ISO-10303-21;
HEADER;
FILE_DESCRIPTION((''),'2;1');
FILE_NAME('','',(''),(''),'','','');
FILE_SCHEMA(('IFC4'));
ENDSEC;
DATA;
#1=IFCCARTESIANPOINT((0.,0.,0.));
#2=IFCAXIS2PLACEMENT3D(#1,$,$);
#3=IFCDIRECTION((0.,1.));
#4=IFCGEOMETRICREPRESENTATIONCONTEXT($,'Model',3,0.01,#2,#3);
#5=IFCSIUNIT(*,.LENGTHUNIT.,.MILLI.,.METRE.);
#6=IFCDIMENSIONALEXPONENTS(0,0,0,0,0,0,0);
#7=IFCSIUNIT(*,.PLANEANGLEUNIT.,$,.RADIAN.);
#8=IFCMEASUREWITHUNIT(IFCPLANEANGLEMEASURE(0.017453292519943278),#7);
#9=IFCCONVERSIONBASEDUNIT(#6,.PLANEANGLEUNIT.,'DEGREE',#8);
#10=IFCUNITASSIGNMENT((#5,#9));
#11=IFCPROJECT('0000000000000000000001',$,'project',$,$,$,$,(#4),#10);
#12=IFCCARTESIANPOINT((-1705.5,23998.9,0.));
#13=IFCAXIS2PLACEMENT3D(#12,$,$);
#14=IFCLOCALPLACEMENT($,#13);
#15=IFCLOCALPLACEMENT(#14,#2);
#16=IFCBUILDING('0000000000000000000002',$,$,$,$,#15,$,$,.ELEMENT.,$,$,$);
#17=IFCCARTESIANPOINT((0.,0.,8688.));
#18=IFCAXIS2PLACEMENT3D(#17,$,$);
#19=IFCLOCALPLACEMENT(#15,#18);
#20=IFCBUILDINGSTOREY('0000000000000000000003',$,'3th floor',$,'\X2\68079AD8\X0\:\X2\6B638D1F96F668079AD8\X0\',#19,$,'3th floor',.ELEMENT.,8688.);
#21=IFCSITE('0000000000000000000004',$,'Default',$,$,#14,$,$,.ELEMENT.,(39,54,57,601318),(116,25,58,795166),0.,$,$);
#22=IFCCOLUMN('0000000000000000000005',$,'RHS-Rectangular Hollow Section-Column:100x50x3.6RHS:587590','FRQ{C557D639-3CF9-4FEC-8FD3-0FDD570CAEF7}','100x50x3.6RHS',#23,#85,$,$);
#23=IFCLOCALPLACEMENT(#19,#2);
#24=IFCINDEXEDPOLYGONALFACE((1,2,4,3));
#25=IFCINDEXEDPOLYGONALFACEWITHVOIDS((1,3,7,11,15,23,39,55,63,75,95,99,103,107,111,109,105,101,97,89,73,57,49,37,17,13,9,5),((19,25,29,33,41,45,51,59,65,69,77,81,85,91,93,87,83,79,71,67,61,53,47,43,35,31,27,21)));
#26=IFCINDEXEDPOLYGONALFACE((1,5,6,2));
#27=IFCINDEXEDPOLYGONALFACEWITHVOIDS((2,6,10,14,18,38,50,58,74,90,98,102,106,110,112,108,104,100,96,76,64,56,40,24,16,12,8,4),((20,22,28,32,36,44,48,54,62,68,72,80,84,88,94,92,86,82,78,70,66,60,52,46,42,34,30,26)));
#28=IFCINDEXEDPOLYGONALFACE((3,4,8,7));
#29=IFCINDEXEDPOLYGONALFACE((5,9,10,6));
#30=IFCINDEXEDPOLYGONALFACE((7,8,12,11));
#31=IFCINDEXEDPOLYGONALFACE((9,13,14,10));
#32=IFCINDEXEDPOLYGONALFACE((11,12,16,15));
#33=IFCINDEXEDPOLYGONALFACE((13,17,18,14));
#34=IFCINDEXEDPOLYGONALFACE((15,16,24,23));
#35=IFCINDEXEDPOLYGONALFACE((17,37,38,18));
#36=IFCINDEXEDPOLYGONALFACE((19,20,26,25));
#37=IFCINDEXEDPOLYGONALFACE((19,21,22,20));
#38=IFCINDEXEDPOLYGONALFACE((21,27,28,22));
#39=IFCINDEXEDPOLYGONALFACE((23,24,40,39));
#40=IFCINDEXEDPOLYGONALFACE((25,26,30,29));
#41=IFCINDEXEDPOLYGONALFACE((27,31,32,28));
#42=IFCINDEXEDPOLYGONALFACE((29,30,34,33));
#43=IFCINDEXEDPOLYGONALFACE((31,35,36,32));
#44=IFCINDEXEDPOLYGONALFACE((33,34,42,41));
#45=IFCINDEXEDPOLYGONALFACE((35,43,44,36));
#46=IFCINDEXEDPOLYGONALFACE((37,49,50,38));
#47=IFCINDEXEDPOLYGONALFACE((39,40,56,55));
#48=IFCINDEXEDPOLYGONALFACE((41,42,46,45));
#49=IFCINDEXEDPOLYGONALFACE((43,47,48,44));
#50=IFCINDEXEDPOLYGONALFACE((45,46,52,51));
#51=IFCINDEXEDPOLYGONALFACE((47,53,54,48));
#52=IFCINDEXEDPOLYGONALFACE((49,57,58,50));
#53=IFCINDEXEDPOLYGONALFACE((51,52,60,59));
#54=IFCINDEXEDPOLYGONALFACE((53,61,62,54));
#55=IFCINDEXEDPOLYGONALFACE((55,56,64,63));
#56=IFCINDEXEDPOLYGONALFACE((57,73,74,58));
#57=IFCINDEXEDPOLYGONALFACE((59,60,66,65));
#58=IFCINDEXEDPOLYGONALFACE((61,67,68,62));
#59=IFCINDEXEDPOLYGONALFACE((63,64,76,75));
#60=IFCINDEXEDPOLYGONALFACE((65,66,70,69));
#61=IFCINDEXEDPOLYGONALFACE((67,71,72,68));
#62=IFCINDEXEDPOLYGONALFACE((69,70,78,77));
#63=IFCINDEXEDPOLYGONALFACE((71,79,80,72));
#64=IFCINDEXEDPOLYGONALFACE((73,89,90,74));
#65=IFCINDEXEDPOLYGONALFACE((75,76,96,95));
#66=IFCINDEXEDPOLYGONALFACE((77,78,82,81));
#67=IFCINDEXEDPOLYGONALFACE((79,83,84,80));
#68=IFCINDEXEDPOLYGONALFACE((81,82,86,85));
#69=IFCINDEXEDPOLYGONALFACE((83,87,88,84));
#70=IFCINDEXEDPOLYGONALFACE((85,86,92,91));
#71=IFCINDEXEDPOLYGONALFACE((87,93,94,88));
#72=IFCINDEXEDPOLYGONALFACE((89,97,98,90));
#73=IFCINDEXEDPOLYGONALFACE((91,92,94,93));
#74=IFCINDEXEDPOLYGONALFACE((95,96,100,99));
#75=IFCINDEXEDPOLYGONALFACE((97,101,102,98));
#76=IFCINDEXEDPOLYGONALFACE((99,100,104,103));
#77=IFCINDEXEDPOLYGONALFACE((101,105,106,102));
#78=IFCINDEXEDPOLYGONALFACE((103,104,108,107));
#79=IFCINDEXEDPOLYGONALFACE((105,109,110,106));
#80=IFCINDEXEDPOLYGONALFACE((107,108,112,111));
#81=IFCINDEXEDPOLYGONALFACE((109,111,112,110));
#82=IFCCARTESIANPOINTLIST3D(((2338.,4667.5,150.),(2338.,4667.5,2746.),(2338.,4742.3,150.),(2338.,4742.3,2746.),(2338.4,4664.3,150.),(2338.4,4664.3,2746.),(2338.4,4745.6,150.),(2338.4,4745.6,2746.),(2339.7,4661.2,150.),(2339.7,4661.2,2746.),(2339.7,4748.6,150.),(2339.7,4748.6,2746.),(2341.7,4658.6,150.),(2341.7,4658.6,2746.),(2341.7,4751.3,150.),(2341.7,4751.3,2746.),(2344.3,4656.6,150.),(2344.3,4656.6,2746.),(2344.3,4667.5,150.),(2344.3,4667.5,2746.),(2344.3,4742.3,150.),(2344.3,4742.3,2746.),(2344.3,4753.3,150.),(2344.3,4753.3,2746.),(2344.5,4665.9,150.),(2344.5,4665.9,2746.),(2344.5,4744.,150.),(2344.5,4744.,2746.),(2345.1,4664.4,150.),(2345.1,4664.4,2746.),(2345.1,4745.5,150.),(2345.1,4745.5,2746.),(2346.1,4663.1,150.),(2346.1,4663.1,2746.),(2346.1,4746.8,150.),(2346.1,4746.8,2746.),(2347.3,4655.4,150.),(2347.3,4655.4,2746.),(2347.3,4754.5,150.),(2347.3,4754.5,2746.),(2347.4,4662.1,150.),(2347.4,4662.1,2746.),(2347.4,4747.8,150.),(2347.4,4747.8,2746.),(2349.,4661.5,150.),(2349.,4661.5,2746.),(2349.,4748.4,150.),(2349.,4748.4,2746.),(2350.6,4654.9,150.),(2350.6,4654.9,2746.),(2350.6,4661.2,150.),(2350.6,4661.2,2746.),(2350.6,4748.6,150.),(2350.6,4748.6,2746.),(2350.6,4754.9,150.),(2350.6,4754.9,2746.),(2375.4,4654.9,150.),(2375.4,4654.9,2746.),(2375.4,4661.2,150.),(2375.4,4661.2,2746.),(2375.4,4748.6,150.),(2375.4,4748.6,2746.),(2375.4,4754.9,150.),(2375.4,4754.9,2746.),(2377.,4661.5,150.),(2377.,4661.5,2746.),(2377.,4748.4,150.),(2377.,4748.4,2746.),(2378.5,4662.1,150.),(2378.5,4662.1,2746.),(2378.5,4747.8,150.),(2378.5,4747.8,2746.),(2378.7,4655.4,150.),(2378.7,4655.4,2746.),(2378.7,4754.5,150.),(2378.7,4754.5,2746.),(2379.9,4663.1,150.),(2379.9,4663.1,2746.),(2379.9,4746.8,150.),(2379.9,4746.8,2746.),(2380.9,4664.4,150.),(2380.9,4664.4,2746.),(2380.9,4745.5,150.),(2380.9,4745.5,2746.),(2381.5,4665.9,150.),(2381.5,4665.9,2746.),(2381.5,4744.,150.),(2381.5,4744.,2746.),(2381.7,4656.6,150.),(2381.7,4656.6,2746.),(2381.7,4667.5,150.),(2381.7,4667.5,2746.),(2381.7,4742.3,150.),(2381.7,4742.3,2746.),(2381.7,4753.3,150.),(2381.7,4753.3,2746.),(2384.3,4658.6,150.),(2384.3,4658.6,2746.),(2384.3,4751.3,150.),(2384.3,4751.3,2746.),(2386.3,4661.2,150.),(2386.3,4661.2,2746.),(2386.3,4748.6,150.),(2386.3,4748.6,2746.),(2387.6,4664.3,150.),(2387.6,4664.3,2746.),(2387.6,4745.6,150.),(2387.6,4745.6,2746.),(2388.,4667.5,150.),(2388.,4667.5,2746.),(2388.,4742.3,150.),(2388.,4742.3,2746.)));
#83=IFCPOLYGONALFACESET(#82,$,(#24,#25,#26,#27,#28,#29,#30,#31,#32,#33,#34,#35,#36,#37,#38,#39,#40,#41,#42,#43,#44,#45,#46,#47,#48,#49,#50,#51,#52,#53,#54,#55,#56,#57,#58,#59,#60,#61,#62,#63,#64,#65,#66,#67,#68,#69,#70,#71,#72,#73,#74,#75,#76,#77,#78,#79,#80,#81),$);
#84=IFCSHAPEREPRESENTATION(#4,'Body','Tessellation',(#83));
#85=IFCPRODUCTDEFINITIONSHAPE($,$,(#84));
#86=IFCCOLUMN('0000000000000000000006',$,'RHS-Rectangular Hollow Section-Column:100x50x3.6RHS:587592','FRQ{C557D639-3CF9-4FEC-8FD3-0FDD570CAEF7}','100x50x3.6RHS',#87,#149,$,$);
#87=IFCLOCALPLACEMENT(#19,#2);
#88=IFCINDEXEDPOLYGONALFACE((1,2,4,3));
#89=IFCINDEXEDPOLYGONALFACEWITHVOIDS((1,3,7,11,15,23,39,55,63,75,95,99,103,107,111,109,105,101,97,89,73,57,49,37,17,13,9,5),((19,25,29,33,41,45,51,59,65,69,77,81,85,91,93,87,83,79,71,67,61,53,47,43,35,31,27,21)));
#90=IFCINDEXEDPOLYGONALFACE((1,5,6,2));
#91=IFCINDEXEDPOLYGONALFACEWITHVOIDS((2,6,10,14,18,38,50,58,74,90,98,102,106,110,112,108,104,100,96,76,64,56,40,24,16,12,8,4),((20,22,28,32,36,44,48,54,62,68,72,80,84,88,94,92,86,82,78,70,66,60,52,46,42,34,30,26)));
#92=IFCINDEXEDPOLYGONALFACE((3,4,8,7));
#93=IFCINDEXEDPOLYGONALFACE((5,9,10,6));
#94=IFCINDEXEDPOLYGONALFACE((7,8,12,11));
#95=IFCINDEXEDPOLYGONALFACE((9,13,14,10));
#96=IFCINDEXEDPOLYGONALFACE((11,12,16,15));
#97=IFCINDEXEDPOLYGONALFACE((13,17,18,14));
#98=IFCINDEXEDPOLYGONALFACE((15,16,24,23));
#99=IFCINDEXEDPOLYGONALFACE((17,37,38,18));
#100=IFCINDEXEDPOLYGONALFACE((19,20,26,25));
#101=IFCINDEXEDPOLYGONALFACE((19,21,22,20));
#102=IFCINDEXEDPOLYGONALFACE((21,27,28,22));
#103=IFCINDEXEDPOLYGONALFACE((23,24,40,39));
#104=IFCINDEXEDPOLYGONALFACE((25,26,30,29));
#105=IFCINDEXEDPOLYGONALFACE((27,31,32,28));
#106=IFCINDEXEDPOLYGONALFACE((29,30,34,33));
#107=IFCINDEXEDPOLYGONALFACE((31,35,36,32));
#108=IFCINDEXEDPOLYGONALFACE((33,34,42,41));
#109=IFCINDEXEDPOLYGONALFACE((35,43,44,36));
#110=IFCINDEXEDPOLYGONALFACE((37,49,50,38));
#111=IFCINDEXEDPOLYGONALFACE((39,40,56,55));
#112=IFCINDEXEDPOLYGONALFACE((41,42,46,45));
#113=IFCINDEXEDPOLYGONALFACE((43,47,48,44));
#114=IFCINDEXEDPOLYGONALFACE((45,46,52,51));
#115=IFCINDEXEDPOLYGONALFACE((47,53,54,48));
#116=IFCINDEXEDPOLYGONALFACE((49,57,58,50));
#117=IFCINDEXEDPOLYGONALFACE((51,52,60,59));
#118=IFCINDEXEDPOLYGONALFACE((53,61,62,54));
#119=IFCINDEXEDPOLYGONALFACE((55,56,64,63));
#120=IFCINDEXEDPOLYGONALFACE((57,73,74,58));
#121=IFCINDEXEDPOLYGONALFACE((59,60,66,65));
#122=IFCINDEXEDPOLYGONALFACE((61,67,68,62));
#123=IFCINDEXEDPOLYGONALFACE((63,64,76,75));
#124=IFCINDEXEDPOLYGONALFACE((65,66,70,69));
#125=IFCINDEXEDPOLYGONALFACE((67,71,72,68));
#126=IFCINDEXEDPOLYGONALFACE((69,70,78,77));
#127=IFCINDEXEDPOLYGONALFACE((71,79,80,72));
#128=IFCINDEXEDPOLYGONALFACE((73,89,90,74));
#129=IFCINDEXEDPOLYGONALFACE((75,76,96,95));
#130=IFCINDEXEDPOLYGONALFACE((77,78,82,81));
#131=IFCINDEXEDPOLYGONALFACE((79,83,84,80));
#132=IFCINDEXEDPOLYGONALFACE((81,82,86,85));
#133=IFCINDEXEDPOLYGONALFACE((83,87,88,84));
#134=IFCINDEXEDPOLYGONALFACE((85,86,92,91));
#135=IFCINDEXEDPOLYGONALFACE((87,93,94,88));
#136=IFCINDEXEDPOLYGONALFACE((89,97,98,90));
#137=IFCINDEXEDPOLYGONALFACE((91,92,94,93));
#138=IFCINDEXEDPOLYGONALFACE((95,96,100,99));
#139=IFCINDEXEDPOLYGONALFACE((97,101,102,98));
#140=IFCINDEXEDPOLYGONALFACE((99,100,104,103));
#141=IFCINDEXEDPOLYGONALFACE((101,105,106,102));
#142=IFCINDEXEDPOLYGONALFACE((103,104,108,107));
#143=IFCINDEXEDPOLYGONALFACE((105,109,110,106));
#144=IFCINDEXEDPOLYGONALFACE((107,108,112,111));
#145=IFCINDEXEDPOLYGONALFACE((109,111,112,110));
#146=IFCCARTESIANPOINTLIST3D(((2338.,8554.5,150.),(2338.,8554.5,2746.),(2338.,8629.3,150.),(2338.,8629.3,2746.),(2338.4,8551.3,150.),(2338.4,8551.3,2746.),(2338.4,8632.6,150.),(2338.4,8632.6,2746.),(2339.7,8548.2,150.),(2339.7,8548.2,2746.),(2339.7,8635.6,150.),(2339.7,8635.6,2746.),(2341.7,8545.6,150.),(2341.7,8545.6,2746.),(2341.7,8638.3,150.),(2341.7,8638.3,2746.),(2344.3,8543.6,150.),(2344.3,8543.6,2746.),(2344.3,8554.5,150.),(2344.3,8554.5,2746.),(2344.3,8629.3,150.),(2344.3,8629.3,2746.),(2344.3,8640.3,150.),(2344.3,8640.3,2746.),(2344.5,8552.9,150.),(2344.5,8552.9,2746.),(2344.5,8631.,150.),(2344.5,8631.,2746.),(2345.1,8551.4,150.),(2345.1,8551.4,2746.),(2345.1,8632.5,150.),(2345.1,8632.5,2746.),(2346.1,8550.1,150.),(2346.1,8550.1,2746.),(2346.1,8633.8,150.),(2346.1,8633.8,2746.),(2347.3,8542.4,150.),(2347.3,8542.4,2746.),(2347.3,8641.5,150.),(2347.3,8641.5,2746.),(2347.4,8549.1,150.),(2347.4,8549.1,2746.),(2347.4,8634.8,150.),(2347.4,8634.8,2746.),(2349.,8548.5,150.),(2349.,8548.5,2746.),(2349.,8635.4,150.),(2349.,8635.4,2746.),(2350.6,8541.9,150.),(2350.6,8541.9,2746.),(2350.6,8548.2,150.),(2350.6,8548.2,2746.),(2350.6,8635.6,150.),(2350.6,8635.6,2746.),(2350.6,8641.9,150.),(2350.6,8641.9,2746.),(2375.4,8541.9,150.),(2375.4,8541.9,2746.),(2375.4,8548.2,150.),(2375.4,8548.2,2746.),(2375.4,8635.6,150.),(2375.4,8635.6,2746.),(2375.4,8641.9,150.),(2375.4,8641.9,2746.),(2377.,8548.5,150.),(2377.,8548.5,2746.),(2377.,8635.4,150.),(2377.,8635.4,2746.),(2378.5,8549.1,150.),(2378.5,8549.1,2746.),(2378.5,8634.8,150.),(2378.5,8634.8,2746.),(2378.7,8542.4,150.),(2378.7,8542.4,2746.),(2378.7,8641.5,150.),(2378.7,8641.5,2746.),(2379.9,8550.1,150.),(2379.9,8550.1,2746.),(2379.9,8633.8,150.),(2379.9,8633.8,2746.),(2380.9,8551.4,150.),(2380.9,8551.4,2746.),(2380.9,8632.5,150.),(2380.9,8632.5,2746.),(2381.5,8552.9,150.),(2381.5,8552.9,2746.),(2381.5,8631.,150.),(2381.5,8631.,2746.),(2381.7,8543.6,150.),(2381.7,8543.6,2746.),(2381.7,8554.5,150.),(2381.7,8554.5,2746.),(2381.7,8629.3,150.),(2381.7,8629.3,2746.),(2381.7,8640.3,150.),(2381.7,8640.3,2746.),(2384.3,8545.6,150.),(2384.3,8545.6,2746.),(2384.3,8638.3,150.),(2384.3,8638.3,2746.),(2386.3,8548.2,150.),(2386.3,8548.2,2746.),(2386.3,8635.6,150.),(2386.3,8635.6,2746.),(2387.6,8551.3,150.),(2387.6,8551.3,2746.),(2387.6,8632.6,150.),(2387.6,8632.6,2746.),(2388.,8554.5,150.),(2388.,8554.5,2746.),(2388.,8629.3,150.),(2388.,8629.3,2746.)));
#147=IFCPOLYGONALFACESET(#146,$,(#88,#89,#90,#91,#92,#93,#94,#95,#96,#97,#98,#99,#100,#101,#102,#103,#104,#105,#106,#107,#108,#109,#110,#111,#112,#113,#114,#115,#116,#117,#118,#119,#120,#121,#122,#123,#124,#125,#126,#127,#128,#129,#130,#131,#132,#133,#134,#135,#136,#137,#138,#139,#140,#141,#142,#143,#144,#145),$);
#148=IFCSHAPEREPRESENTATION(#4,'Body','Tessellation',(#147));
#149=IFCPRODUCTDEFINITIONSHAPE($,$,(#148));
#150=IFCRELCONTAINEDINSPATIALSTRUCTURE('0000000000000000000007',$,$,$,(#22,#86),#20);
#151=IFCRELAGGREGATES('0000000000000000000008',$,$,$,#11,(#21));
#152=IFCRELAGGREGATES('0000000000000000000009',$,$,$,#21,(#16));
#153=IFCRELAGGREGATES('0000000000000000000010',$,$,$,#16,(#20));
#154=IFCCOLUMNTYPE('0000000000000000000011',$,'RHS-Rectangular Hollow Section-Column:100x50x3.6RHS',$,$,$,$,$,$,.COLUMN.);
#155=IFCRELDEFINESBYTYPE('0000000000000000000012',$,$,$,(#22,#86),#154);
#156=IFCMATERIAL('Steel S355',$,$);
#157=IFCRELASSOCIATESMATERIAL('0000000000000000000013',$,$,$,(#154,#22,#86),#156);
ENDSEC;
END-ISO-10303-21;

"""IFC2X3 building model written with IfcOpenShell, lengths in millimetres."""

from ifc_helpers import new_model, entity, si_unit, converted_unit, direction, frame, origin, origin_2d, place, context, project, spatial, hollow_rectangle, extrude, clip, halfspace, material, type_object, element, save


model = new_model("IFC2X3")

# Units and contexts
model_context = context("Model", 3, precision=0.01, world=origin(), true_north=direction((0.0, 1.0)))
ifc_project = project(units=[si_unit("LENGTHUNIT", "METRE", prefix="MILLI"), converted_unit("PLANEANGLEUNIT", "DEGREE", entity("IfcPlaneAngleMeasure", 0.017453292519943278), si_unit("PLANEANGLEUNIT", "RADIAN"), dimensions=[0, 0, 0, 0, 0, 0, 0])], contexts=[model_context])

# Site, building, storey
site_placement = place(None, frame((-1705.5, 23998.9, 0.0)))
site = spatial("IfcSite", under=ifc_project, at=site_placement, Name="Default", CompositionType="ELEMENT", RefLatitude=(39, 54, 57, 601318), RefLongitude=(116, 25, 58, 795166), RefElevation=0.0)
building_placement = place(site_placement, origin())
building = spatial("IfcBuilding", under=site, at=building_placement, CompositionType="ELEMENT")
storey_placement = place(building_placement, frame((0.0, 0.0, 8688.0)))
storey = spatial("IfcBuildingStorey", under=building, at=storey_placement, Name="3th floor", ObjectType="标高:正负零标高", LongName="3th floor", CompositionType="ELEMENT", Elevation=8688.0)

# Columns
ifc_material_1 = material(Name="Steel S355")
column_type_1 = type_object("IfcColumnType", Name="RHS-Rectangular Hollow Section-Column:100x50x3.6RHS", PredefinedType="COLUMN", material=ifc_material_1)
column_1_placement = place(storey_placement, frame((2363.0, 4704.9, 2746.0)))
element("IfcColumn", 1, at=column_1_placement, inside=storey, type_object=column_type_1, material=ifc_material_1, Name="RHS-Rectangular Hollow Section-Column:100x50x3.6RHS:587590", Description="FRQ{C557D639-3CF9-4FEC-8FD3-0FDD570CAEF7}", ObjectType="100x50x3.6RHS", context=model_context, shape_type="Clipping", body=[
    clip(extrude(hollow_rectangle(XDim=50.0, YDim=100.0, WallThickness=6.3, InnerFilletRadius=6.3, OuterFilletRadius=12.6, at=origin_2d()), origin(), (0.0, 0.0, -1.0), 2651.9), halfspace(frame((-2363.0, -4704.9, -2596.0), z_axis=(0.0, 0.0, 1.0), x_axis=(1.0, 0.0, 0.0)), True)),
])
column_2_placement = place(storey_placement, frame((2363.0, 8591.9, 2746.0)))
element("IfcColumn", 2, at=column_2_placement, inside=storey, type_object=column_type_1, material=ifc_material_1, Name="RHS-Rectangular Hollow Section-Column:100x50x3.6RHS:587592", Description="FRQ{C557D639-3CF9-4FEC-8FD3-0FDD570CAEF7}", ObjectType="100x50x3.6RHS", context=model_context, shape_type="Clipping", body=[
    clip(extrude(hollow_rectangle(XDim=50.0, YDim=100.0, WallThickness=6.3, InnerFilletRadius=6.3, OuterFilletRadius=12.6, at=origin_2d()), origin(), (0.0, 0.0, -1.0), 2651.9), halfspace(frame((-2363.0, -8591.9, -2596.0), z_axis=(0.0, 0.0, 1.0), x_axis=(1.0, 0.0, 0.0)), True)),
])

save(model, "model.ifc")
